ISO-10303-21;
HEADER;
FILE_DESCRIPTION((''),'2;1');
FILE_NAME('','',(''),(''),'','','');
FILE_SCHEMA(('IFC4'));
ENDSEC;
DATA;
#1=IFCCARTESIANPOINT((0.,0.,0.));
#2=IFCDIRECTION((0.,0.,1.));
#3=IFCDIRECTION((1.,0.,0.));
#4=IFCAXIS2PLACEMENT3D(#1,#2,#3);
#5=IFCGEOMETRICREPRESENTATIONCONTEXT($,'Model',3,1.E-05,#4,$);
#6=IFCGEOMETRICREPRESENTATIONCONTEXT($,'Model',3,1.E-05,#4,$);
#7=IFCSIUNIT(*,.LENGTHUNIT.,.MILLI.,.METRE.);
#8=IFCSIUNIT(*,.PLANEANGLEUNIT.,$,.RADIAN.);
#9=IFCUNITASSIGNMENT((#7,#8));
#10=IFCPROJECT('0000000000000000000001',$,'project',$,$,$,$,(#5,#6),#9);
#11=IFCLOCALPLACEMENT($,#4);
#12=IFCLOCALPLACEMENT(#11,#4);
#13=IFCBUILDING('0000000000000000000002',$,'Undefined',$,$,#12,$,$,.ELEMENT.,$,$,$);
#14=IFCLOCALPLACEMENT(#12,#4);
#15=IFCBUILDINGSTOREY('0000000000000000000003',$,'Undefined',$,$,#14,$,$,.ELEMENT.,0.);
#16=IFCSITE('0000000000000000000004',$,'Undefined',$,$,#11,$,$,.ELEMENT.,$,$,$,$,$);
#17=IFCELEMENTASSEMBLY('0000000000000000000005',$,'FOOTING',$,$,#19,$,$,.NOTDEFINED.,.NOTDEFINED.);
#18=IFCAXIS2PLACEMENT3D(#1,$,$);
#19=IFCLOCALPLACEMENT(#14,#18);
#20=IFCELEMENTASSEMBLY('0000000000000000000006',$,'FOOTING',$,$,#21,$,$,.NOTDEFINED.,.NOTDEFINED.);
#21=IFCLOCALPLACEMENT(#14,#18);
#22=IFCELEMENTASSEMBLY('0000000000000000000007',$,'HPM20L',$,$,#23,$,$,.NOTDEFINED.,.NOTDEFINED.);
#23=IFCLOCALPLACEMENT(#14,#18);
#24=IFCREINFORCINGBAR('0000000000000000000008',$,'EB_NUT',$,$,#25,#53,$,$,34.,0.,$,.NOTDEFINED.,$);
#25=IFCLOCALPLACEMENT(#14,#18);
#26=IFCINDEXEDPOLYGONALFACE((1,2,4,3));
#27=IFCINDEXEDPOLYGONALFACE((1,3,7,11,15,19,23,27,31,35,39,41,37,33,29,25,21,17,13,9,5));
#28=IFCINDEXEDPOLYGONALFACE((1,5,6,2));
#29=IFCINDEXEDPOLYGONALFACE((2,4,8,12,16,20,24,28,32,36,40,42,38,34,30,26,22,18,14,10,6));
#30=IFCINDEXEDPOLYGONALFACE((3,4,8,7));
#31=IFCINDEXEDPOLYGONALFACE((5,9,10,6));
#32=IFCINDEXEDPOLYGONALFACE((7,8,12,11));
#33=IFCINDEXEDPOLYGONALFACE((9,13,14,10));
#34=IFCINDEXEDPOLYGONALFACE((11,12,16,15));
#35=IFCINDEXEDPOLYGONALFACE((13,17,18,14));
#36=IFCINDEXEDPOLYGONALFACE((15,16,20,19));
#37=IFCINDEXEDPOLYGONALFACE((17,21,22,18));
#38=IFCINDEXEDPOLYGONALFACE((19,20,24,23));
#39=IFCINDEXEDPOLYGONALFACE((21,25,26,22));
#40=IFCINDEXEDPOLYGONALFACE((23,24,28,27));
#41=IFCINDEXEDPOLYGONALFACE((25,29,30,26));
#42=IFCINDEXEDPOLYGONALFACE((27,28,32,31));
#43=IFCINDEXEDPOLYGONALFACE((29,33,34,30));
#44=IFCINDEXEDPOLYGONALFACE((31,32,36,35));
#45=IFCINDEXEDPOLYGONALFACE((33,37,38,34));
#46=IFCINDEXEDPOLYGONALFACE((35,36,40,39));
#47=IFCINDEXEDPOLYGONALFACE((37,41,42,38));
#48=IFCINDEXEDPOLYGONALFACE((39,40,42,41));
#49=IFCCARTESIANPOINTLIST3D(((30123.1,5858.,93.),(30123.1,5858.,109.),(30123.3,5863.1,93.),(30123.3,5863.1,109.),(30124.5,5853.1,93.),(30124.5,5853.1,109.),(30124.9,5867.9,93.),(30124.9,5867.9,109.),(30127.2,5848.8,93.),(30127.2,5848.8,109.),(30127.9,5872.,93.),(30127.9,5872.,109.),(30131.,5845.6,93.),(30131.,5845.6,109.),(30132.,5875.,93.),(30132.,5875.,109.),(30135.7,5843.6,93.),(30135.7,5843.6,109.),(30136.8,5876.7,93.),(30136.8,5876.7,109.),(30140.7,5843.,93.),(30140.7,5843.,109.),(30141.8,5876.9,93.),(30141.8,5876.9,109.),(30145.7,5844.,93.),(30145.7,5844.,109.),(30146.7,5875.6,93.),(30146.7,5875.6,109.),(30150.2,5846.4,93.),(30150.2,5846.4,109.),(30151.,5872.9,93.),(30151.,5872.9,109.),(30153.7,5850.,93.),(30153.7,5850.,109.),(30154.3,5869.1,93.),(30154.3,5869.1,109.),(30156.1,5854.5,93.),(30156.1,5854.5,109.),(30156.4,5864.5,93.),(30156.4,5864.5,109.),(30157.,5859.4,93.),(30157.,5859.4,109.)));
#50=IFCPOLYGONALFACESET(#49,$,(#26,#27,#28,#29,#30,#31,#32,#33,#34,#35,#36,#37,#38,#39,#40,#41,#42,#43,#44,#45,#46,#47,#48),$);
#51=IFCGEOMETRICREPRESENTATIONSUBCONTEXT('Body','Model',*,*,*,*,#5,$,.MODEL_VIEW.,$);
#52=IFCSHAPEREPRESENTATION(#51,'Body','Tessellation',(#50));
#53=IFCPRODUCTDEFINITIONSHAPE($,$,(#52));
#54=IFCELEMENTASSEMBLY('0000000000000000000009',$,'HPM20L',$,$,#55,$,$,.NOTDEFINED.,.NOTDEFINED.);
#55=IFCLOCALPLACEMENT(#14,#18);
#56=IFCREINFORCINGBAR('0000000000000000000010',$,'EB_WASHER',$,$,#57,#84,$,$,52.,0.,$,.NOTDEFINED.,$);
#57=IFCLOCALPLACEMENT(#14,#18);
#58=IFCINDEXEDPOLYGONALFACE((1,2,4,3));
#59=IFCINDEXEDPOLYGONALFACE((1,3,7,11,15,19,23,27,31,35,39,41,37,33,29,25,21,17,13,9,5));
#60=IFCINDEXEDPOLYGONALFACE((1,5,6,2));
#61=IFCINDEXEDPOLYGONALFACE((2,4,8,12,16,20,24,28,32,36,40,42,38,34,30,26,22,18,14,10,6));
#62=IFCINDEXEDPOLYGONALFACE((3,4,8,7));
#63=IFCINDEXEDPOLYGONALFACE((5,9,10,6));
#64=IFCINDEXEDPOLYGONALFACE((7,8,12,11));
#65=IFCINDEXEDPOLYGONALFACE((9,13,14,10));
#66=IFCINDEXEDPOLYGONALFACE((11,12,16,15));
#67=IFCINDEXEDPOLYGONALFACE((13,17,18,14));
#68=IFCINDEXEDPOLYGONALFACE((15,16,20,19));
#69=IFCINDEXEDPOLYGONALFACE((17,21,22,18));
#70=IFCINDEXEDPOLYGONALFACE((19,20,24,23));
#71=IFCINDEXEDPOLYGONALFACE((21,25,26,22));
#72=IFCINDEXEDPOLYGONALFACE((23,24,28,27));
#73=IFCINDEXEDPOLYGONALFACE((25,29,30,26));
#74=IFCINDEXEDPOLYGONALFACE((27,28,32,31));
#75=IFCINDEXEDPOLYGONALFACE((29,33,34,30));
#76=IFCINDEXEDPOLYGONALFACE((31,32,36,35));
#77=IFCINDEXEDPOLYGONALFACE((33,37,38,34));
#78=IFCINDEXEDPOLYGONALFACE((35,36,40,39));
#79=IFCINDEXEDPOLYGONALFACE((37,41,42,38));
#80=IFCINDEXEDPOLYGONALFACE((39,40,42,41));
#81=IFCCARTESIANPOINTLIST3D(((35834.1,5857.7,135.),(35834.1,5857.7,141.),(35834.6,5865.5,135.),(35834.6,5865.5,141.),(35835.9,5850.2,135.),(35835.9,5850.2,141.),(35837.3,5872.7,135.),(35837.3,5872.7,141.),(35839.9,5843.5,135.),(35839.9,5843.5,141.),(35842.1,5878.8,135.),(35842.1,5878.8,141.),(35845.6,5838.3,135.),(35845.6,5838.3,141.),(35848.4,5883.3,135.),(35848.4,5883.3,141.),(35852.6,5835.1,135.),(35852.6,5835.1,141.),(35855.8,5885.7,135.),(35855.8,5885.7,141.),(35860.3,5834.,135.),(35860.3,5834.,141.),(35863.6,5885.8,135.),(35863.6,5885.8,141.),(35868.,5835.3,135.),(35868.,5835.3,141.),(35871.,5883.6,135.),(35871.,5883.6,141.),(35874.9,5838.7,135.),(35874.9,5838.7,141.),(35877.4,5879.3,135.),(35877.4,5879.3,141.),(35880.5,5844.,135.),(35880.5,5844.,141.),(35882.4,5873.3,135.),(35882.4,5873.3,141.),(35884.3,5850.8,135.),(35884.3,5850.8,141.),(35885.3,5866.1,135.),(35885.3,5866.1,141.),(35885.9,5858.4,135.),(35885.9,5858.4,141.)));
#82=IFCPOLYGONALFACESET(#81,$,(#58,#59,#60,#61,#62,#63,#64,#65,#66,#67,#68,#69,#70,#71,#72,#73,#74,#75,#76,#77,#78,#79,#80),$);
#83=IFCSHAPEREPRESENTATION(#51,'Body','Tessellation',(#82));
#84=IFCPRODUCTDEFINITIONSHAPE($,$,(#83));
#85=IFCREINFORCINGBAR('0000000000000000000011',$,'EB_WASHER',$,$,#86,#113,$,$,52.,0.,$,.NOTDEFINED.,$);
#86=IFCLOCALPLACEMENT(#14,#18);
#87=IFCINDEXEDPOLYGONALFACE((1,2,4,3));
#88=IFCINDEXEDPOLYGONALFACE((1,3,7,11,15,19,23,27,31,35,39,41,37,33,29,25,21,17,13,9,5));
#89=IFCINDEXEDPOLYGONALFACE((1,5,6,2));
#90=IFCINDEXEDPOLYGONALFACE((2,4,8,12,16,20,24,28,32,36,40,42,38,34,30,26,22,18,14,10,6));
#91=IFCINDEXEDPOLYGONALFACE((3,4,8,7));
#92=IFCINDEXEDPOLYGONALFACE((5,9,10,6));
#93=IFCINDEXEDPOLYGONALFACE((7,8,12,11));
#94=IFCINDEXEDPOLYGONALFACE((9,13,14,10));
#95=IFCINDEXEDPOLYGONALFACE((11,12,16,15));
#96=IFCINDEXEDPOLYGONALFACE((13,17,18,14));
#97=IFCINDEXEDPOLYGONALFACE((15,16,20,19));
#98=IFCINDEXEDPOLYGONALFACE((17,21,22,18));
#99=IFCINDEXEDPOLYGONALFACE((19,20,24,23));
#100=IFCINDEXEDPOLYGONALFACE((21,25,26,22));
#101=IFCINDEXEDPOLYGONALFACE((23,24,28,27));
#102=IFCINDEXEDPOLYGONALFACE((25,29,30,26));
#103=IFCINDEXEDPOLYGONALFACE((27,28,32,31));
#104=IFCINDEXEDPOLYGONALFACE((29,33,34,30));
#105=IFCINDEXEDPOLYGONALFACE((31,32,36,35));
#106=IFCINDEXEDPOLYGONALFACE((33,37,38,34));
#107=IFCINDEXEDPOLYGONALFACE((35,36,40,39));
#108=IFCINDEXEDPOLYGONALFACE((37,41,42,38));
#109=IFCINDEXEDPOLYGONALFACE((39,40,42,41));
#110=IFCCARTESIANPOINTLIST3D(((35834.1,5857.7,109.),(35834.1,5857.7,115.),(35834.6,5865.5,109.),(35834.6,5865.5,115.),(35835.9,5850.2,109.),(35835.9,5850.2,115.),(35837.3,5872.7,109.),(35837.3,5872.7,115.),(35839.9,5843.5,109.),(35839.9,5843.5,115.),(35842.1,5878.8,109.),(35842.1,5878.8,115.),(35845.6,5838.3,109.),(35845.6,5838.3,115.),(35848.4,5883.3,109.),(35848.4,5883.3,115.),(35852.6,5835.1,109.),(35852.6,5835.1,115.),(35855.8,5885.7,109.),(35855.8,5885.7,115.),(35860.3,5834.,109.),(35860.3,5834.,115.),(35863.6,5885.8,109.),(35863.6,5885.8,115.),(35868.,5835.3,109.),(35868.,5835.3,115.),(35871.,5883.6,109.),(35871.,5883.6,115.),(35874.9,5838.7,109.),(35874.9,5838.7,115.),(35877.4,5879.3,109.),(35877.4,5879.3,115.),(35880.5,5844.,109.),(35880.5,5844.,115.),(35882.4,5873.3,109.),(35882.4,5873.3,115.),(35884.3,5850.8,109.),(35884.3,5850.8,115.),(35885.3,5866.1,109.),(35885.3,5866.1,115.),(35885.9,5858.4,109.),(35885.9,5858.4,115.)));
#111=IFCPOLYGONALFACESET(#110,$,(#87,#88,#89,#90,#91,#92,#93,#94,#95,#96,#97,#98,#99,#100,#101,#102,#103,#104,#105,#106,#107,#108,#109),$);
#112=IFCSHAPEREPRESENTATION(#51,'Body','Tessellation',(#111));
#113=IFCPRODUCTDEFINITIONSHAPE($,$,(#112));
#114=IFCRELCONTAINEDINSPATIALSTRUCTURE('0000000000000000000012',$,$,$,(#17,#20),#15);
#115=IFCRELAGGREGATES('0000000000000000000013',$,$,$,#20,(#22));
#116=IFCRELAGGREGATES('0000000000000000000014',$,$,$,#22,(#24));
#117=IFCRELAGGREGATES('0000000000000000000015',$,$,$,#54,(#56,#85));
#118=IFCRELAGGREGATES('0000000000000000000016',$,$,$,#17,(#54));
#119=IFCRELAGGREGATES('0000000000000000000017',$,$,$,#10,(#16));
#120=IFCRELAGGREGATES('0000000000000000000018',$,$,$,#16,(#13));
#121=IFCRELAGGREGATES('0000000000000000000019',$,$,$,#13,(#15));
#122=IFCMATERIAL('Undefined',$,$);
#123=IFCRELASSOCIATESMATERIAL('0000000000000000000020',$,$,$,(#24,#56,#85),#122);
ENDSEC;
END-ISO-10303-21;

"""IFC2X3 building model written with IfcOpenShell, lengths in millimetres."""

from ifc_helpers import new_model, entity, si_unit, frame, origin_with_axes, place, context, subcontext, project, spatial, source, transform, mapped, material, element, aggregate, save


model = new_model("IFC2X3")

# Units and contexts
model_context_1 = context("Model", 3, precision=1e-05, world=origin_with_axes())
model_context_2 = context("Model", 3, precision=1e-05, world=origin_with_axes())
body_context = subcontext(model_context_1, "Body", "Model", "MODEL_VIEW")
ifc_project = project(units=[si_unit("LENGTHUNIT", "METRE", prefix="MILLI"), si_unit("PLANEANGLEUNIT", "RADIAN")], contexts=[model_context_1, model_context_2])

# Site, building, storey
site_placement = place(None, origin_with_axes())
site = spatial("IfcSite", under=ifc_project, at=site_placement, Name="Undefined", CompositionType="ELEMENT")
building_placement = place(site_placement, origin_with_axes())
building = spatial("IfcBuilding", under=site, at=building_placement, Name="Undefined", CompositionType="ELEMENT")
storey_placement = place(building_placement, origin_with_axes())
storey = spatial("IfcBuildingStorey", under=building, at=storey_placement, Name="Undefined", CompositionType="ELEMENT", Elevation=0.0)

# Element assembly
assembly_1_placement = place(storey_placement, origin_with_axes())
assembly_1 = element("IfcElementAssembly", 1, at=assembly_1_placement, inside=storey, Name="FOOTING", AssemblyPlace="NOTDEFINED", PredefinedType="NOTDEFINED")

# Element assemblies
assembly_2_placement = place(storey_placement, origin_with_axes())
assembly_2 = element("IfcElementAssembly", 2, at=assembly_2_placement, inside=storey, Name="FOOTING", AssemblyPlace="NOTDEFINED", PredefinedType="NOTDEFINED")
assembly_3_placement = place(assembly_2_placement, origin_with_axes())
assembly_3 = element("IfcElementAssembly", 3, at=assembly_3_placement, Name="HPM20L", AssemblyPlace="NOTDEFINED", PredefinedType="NOTDEFINED")
aggregate(assembly_2, [assembly_3])

# Shared definitions
ifc_material_1 = material(Name="Undefined")

# Reinforcing bar
shared_shape_1 = source(origin_with_axes(), body_context, "Body", "AdvancedSweptSolid", [
    entity("IfcSweptDiskSolid", entity("IfcTrimmedCurve", entity("IfcLine", entity("IfcCartesianPoint", [0.0, 0.0, 0.0]), entity("IfcVector", entity("IfcDirection", [1.0, 0.0, 0.0]), 1.0)), [entity("IfcParameterValue", 0.0)], [entity("IfcParameterValue", 16.0)], True, "PARAMETER"), 17.0, None, 0.0, 16.0),
])
reinforcing_bar_1_placement = place(assembly_3_placement, frame((30140.0, 5860.0, 109.0), z_axis=(-0.190852, 0.981619, 0.0), x_axis=(0.0, 0.0, -1.0)))
reinforcing_bar_1 = element("IfcReinforcingBar", 4, at=reinforcing_bar_1_placement, material=ifc_material_1, Name="EB_NUT", BarRole="NOTDEFINED", CrossSectionArea=0.0, NominalDiameter=34.0, context=body_context, shape_type="MappedRepresentation", body=[
    mapped(shared_shape_1, transform((0.0, 0.0, 0.0))),
])
aggregate(assembly_3, [reinforcing_bar_1])

# Element assembly, reinforcing bars
assembly_4_placement = place(assembly_1_placement, origin_with_axes())
assembly_4 = element("IfcElementAssembly", 5, at=assembly_4_placement, Name="HPM20L", AssemblyPlace="NOTDEFINED", PredefinedType="NOTDEFINED")
shared_shape_2 = source(origin_with_axes(), body_context, "Body", "AdvancedSweptSolid", [
    entity("IfcSweptDiskSolid", entity("IfcTrimmedCurve", entity("IfcLine", entity("IfcCartesianPoint", [0.0, 0.0, 0.0]), entity("IfcVector", entity("IfcDirection", [1.0, 0.0, 0.0]), 1.0)), [entity("IfcParameterValue", 0.0)], [entity("IfcParameterValue", 6.0)], True, "PARAMETER"), 26.0, None, 0.0, 6.0),
])
reinforcing_bar_2_placement = place(assembly_4_placement, frame((35860.0, 5860.0, 141.0), z_axis=(-0.161274, 0.98691, 0.0), x_axis=(0.0, 0.0, -1.0)))
reinforcing_bar_2 = element("IfcReinforcingBar", 6, at=reinforcing_bar_2_placement, material=ifc_material_1, Name="EB_WASHER", BarRole="NOTDEFINED", CrossSectionArea=0.0, NominalDiameter=52.0, context=body_context, shape_type="MappedRepresentation", body=[
    mapped(shared_shape_2, transform((0.0, 0.0, 0.0))),
])
shared_shape_3 = source(origin_with_axes(), body_context, "Body", "AdvancedSweptSolid", [
    entity("IfcSweptDiskSolid", entity("IfcTrimmedCurve", entity("IfcLine", entity("IfcCartesianPoint", [0.0, 0.0, 0.0]), entity("IfcVector", entity("IfcDirection", [1.0, 0.0, 0.0]), 1.0)), [entity("IfcParameterValue", 0.0)], [entity("IfcParameterValue", 6.0)], True, "PARAMETER"), 26.0, None, 0.0, 6.0),
])
reinforcing_bar_3_placement = place(assembly_4_placement, frame((35860.0, 5860.0, 115.0), z_axis=(-0.161274, 0.98691, 0.0), x_axis=(0.0, 0.0, -1.0)))
reinforcing_bar_3 = element("IfcReinforcingBar", 7, at=reinforcing_bar_3_placement, material=ifc_material_1, Name="EB_WASHER", BarRole="NOTDEFINED", CrossSectionArea=0.0, NominalDiameter=52.0, context=body_context, shape_type="MappedRepresentation", body=[
    mapped(shared_shape_3, transform((0.0, 0.0, 0.0))),
])
aggregate(assembly_4, [reinforcing_bar_2, reinforcing_bar_3])

aggregate(assembly_1, [assembly_4])

save(model, "model.ifc")
